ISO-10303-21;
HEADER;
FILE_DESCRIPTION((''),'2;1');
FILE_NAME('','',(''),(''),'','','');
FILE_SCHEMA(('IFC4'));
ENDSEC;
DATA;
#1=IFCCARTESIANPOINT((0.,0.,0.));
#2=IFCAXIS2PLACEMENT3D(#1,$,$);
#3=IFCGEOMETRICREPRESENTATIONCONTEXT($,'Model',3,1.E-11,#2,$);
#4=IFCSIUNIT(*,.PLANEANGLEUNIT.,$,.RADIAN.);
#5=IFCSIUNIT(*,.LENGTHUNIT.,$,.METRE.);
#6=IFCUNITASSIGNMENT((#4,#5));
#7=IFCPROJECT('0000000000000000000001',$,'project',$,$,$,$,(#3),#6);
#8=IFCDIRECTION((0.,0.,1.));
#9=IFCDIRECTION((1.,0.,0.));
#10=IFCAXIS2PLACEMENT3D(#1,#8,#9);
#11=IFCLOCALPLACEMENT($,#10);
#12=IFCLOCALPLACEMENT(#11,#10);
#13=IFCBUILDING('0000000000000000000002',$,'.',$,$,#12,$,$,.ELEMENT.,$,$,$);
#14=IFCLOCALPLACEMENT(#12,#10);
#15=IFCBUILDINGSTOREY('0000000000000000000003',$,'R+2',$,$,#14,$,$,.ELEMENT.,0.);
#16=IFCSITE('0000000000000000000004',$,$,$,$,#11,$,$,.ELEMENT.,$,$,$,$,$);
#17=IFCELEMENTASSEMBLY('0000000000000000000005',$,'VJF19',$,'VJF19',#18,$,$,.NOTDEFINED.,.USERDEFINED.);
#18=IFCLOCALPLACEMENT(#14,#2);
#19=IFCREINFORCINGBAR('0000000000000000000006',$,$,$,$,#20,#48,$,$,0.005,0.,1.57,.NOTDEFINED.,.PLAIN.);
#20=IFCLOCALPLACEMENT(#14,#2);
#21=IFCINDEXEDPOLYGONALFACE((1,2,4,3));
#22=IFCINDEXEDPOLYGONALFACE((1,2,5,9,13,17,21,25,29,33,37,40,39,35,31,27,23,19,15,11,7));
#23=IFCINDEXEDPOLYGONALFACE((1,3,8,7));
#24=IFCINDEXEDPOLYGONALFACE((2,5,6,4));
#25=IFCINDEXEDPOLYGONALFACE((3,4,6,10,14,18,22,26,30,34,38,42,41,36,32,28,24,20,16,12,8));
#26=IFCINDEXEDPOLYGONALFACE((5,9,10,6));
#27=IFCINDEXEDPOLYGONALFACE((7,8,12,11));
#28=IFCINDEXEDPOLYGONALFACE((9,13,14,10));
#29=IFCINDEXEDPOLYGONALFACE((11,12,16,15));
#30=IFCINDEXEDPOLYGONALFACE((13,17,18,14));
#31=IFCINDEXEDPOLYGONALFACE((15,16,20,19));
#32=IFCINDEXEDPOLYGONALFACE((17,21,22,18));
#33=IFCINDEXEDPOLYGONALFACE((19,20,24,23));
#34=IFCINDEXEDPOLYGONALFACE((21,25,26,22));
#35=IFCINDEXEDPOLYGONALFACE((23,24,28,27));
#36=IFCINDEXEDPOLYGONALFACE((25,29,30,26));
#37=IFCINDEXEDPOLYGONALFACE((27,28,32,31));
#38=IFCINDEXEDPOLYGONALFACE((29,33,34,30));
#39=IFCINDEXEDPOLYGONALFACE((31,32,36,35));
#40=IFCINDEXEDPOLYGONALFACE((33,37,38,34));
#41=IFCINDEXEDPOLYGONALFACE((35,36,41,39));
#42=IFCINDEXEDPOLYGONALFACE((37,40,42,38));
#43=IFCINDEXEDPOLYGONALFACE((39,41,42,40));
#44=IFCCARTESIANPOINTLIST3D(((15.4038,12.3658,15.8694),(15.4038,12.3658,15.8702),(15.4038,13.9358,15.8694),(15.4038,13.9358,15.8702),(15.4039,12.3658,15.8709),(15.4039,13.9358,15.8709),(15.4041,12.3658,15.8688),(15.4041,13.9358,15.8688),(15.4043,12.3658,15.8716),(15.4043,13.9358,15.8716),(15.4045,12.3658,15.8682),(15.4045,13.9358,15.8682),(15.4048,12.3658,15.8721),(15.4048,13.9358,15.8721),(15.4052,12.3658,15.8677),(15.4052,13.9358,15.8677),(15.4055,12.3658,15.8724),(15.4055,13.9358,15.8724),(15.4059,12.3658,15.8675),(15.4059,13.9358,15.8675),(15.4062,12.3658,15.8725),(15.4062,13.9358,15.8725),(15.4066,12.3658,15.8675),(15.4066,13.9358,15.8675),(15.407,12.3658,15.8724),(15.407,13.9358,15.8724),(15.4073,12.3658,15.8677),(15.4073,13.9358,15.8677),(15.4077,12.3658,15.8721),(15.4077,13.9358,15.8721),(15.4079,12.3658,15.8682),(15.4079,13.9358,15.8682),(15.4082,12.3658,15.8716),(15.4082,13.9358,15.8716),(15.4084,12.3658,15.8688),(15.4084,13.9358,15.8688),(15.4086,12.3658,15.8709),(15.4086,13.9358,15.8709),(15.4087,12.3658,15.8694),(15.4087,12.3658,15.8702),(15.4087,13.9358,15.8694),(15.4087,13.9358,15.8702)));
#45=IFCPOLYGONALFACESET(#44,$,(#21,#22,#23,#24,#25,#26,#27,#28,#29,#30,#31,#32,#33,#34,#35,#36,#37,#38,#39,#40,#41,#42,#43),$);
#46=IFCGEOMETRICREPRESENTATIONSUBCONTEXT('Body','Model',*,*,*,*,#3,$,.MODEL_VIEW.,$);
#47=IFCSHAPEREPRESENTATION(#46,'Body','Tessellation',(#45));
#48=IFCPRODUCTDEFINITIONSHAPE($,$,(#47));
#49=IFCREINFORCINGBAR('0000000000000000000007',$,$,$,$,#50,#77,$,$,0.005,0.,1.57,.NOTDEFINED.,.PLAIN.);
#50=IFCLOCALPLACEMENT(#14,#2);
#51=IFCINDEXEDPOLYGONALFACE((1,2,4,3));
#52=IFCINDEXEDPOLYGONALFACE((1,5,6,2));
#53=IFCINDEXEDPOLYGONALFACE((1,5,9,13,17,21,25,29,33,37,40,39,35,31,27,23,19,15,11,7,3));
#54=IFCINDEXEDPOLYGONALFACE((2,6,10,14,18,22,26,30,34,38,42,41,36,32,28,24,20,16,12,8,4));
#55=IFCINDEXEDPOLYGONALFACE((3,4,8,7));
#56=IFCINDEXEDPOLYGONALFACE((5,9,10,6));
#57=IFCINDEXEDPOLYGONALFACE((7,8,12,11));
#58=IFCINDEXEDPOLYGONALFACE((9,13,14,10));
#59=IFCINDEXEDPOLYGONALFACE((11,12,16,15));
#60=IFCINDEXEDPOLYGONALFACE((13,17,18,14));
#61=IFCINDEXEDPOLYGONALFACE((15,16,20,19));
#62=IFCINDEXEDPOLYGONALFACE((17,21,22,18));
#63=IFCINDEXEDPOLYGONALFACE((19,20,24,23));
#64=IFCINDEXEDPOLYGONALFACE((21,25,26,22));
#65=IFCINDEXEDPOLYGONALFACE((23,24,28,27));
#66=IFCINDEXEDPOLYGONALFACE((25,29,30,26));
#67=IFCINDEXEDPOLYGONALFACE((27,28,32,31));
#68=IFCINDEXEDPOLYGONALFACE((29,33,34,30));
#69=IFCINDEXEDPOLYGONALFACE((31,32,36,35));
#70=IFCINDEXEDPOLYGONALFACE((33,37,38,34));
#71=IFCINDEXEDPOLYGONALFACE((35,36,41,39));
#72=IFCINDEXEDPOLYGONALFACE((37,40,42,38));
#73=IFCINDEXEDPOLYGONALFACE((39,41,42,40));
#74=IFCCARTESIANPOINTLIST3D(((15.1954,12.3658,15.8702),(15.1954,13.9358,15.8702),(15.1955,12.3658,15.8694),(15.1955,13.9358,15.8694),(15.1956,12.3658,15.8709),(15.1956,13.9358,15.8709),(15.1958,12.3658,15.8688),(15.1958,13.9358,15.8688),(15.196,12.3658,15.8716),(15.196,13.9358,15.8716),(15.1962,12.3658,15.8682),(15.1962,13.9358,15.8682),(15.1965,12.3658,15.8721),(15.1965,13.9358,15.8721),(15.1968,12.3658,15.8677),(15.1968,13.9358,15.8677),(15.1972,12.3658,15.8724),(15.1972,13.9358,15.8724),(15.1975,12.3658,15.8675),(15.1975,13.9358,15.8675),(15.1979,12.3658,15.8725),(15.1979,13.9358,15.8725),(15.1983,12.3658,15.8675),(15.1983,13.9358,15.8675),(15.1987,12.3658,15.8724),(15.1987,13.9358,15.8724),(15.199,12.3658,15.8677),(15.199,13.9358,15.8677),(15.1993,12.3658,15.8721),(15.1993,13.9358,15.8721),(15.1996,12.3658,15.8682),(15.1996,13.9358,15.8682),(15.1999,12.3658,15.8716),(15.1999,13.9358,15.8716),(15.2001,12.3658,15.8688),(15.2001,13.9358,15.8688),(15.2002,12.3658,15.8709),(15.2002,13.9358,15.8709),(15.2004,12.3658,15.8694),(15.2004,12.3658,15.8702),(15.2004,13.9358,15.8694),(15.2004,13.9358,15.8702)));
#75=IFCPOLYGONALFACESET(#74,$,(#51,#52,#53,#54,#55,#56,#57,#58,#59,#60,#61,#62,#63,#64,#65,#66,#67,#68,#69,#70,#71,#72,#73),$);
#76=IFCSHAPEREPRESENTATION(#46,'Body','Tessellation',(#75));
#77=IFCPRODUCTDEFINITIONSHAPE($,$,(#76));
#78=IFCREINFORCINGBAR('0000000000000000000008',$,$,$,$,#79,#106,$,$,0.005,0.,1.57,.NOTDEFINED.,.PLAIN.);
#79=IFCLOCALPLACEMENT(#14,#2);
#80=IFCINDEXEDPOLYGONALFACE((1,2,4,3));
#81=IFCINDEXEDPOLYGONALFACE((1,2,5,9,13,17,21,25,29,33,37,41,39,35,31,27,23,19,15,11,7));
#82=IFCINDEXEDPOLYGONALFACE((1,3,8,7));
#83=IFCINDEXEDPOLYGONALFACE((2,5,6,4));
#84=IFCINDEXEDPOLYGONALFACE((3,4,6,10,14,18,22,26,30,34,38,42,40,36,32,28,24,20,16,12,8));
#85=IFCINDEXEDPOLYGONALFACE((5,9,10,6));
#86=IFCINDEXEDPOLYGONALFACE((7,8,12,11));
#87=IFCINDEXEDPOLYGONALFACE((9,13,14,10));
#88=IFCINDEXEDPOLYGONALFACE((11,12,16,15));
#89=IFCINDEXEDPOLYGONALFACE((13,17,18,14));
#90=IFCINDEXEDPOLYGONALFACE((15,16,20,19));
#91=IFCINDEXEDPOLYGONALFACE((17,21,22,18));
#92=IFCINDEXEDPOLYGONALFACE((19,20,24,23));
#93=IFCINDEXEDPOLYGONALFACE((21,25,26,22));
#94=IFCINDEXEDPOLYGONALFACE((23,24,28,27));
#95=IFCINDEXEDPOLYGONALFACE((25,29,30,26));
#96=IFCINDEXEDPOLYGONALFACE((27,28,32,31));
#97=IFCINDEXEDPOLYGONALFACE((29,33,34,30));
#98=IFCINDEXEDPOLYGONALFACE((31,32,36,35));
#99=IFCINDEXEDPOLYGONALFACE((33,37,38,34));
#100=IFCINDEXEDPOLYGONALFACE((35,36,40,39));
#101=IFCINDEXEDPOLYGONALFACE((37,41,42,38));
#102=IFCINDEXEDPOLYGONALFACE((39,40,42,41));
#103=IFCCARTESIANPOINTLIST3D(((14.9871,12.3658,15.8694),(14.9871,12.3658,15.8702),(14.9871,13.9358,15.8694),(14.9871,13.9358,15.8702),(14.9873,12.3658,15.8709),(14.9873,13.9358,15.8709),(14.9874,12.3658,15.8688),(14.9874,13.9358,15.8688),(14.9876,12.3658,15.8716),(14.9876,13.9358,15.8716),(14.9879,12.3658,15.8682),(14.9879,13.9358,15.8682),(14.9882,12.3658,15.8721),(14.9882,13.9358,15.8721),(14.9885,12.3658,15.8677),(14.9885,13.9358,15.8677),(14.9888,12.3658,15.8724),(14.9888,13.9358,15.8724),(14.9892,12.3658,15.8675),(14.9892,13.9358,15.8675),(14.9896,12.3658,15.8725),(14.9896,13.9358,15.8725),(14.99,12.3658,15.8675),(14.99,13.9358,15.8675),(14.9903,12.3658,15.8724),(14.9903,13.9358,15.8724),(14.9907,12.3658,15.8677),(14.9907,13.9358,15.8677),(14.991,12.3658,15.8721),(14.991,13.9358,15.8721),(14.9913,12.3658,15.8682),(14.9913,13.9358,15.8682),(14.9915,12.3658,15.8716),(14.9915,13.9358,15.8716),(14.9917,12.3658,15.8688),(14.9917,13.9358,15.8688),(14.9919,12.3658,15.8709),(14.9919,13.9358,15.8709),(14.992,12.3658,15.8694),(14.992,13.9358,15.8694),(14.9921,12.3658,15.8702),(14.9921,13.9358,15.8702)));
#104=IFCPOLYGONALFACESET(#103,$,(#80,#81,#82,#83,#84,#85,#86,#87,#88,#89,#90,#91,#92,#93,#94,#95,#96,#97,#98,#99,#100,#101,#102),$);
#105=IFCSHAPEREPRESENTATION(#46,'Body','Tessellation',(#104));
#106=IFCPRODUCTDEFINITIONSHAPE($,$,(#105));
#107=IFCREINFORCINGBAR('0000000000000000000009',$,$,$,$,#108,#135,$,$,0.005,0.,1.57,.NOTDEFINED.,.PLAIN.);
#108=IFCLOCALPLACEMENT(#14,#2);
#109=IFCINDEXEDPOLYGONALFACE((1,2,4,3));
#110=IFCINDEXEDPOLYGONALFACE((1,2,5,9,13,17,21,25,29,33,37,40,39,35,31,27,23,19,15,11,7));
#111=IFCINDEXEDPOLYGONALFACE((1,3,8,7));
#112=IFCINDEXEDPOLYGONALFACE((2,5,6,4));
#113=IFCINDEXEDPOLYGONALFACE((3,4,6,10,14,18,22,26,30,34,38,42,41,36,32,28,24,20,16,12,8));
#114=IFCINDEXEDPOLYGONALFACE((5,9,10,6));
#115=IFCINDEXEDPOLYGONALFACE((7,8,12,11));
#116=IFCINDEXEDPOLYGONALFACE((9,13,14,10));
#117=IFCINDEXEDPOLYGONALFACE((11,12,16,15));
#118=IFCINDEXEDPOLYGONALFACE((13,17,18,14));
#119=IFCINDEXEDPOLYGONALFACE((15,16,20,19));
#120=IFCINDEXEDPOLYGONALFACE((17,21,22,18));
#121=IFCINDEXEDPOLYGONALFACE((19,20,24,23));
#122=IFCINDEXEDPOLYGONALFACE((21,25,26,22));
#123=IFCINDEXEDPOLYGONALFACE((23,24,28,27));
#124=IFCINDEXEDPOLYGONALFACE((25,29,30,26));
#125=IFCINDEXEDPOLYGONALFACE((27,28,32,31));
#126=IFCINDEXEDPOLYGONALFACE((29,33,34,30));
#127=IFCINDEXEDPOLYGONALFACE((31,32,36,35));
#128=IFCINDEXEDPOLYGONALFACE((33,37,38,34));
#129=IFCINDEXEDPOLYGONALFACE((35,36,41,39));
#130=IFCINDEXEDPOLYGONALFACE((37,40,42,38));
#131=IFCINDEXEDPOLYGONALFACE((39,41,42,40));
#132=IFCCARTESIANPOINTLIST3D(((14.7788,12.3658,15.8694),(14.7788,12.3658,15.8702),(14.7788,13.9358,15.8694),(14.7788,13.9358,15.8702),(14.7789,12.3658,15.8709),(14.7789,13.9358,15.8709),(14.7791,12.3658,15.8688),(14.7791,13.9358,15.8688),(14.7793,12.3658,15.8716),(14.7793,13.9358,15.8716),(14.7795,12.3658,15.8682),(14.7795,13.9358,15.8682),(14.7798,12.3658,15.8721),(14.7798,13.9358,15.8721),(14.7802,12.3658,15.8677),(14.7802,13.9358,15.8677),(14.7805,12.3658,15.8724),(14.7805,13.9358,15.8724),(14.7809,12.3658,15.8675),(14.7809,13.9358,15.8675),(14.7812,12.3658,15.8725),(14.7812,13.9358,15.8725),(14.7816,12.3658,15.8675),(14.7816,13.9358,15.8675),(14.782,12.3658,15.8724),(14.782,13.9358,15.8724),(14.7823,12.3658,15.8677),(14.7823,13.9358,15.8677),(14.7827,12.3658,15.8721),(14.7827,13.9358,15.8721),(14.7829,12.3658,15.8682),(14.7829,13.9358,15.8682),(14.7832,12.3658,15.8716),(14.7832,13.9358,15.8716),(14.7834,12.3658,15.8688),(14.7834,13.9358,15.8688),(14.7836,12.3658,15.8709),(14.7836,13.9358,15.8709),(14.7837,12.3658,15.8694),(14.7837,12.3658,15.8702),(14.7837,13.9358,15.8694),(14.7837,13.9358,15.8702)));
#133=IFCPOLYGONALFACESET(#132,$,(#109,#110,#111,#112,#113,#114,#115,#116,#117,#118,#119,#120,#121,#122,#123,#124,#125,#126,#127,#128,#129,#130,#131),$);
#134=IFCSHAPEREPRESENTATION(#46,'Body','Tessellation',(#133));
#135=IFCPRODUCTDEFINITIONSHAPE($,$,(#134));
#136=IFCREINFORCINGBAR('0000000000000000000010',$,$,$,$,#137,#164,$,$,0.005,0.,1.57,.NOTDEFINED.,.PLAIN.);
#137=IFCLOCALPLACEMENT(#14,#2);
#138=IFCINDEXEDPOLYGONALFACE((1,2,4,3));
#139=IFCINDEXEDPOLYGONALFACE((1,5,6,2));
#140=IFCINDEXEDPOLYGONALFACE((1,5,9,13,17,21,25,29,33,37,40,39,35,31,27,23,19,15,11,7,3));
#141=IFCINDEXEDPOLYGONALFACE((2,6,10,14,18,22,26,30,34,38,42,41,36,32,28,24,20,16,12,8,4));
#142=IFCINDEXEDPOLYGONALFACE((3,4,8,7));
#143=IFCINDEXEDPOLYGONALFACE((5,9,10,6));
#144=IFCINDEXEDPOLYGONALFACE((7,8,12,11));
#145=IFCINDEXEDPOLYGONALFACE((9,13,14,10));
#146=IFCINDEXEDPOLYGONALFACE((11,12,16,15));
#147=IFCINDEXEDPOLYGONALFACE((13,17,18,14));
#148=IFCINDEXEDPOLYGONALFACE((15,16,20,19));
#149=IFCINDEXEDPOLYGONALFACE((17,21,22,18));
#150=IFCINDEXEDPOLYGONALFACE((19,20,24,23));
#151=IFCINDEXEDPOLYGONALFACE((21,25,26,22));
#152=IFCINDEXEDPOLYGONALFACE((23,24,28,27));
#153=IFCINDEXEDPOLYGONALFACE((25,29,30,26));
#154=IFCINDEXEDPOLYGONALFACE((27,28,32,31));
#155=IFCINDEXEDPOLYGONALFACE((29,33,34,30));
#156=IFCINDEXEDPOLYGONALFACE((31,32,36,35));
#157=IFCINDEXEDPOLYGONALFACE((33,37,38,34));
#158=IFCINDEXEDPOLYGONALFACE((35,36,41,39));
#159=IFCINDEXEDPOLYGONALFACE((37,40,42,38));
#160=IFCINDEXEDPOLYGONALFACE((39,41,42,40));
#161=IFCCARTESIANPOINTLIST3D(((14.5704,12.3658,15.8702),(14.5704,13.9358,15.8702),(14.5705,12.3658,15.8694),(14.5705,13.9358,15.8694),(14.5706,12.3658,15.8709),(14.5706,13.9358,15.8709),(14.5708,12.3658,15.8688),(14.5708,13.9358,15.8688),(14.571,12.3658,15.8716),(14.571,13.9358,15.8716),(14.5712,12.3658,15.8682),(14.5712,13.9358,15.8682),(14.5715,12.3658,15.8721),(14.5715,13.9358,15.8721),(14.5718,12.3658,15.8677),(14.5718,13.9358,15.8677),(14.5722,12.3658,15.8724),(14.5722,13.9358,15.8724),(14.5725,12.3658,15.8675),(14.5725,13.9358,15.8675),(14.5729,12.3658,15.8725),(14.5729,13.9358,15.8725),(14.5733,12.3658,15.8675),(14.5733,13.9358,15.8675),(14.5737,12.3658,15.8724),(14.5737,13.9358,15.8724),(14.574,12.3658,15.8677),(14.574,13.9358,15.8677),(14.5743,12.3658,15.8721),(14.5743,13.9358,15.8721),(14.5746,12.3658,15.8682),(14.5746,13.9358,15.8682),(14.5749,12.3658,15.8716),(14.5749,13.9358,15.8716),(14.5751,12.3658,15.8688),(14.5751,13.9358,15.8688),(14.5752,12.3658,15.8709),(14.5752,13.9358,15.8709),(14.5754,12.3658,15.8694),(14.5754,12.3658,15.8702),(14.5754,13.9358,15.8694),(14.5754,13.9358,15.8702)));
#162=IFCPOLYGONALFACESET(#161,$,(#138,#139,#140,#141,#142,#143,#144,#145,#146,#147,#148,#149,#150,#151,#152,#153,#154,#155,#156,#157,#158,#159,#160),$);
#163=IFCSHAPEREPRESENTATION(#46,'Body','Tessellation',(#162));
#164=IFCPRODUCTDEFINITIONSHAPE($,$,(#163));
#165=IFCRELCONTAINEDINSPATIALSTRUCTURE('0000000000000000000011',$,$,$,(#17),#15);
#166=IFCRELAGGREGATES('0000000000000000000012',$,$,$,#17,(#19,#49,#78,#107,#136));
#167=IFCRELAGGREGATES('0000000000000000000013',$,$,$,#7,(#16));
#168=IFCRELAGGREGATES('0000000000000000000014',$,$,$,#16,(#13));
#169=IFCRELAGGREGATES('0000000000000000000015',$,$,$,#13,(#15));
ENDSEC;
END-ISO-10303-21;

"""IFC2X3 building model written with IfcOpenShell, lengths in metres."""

from ifc_helpers import new_model, entity, si_unit, origin, origin_with_axes, place, context, subcontext, project, spatial, shape, element, aggregate, save


model = new_model("IFC2X3")

# Units and contexts
model_context = context("Model", 3, precision=1e-11, world=origin())
body_context = subcontext(model_context, "Body", "Model", "MODEL_VIEW")
ifc_project = project(units=[si_unit("PLANEANGLEUNIT", "RADIAN"), si_unit("LENGTHUNIT", "METRE")], contexts=[model_context])

# Site, building, storey
site_placement = place(None, origin_with_axes())
site = spatial("IfcSite", under=ifc_project, at=site_placement, CompositionType="ELEMENT")
building_placement = place(site_placement, origin_with_axes())
building = spatial("IfcBuilding", under=site, at=building_placement, Name=".", CompositionType="ELEMENT")
storey_placement = place(building_placement, origin_with_axes())
storey = spatial("IfcBuildingStorey", under=building, at=storey_placement, Name="R+2", CompositionType="ELEMENT", Elevation=0.0)

# Element assembly, reinforcing bars
assembly_1_placement = place(storey_placement, origin_with_axes())
assembly_1 = element("IfcElementAssembly", 1, at=assembly_1_placement, inside=storey, Name="VJF19", ObjectType="VJF19", AssemblyPlace="NOTDEFINED", PredefinedType="USERDEFINED")
reinforcing_bar_1_placement = place(assembly_1_placement, origin_with_axes())
reinforcing_bar_1 = element("IfcReinforcingBar", 2, at=reinforcing_bar_1_placement, BarLength=1.57, BarRole="NOTDEFINED", BarSurface="PLAIN", CrossSectionArea=0.0, NominalDiameter=0.005, shapes=[
    shape(body_context, "Body", "AdvancedSweptSolid", [entity("IfcSweptDiskSolid", entity("IfcPolyline", [entity("IfcCartesianPoint", [15.4062, 12.3658, 15.87]), entity("IfcCartesianPoint", [15.4062, 13.9358, 15.87])]), 0.0025, None, 0.0, 1.57)]),
    shape(body_context, "Body", "AdvancedSweptSolid", [entity("IfcSweptDiskSolid", entity("IfcPolyline", [entity("IfcCartesianPoint", [15.4062, 12.3658, 15.87]), entity("IfcCartesianPoint", [15.4062, 13.9358, 15.87])]), 0.0025, None, 0.0, 1.57)]),
])
reinforcing_bar_2_placement = place(assembly_1_placement, origin_with_axes())
reinforcing_bar_2 = element("IfcReinforcingBar", 3, at=reinforcing_bar_2_placement, BarLength=1.57, BarRole="NOTDEFINED", BarSurface="PLAIN", CrossSectionArea=0.0, NominalDiameter=0.005, shapes=[
    shape(body_context, "Body", "AdvancedSweptSolid", [entity("IfcSweptDiskSolid", entity("IfcPolyline", [entity("IfcCartesianPoint", [15.1979, 12.3658, 15.87]), entity("IfcCartesianPoint", [15.1979, 13.9358, 15.87])]), 0.0025, None, 0.0, 1.57)]),
    shape(body_context, "Body", "AdvancedSweptSolid", [entity("IfcSweptDiskSolid", entity("IfcPolyline", [entity("IfcCartesianPoint", [15.1979, 12.3658, 15.87]), entity("IfcCartesianPoint", [15.1979, 13.9358, 15.87])]), 0.0025, None, 0.0, 1.57)]),
])
reinforcing_bar_3_placement = place(assembly_1_placement, origin_with_axes())
reinforcing_bar_3 = element("IfcReinforcingBar", 4, at=reinforcing_bar_3_placement, BarLength=1.57, BarRole="NOTDEFINED", BarSurface="PLAIN", CrossSectionArea=0.0, NominalDiameter=0.005, shapes=[
    shape(body_context, "Body", "AdvancedSweptSolid", [entity("IfcSweptDiskSolid", entity("IfcPolyline", [entity("IfcCartesianPoint", [14.9896, 12.3658, 15.87]), entity("IfcCartesianPoint", [14.9896, 13.9358, 15.87])]), 0.0025, None, 0.0, 1.57)]),
    shape(body_context, "Body", "AdvancedSweptSolid", [entity("IfcSweptDiskSolid", entity("IfcPolyline", [entity("IfcCartesianPoint", [14.9896, 12.3658, 15.87]), entity("IfcCartesianPoint", [14.9896, 13.9358, 15.87])]), 0.0025, None, 0.0, 1.57)]),
])
reinforcing_bar_4_placement = place(assembly_1_placement, origin_with_axes())
reinforcing_bar_4 = element("IfcReinforcingBar", 5, at=reinforcing_bar_4_placement, BarLength=1.57, BarRole="NOTDEFINED", BarSurface="PLAIN", CrossSectionArea=0.0, NominalDiameter=0.005, shapes=[
    shape(body_context, "Body", "AdvancedSweptSolid", [entity("IfcSweptDiskSolid", entity("IfcPolyline", [entity("IfcCartesianPoint", [14.7812, 12.3658, 15.87]), entity("IfcCartesianPoint", [14.7812, 13.9358, 15.87])]), 0.0025, None, 0.0, 1.57)]),
    shape(body_context, "Body", "AdvancedSweptSolid", [entity("IfcSweptDiskSolid", entity("IfcPolyline", [entity("IfcCartesianPoint", [14.7812, 12.3658, 15.87]), entity("IfcCartesianPoint", [14.7812, 13.9358, 15.87])]), 0.0025, None, 0.0, 1.57)]),
])
reinforcing_bar_5_placement = place(assembly_1_placement, origin_with_axes())
reinforcing_bar_5 = element("IfcReinforcingBar", 6, at=reinforcing_bar_5_placement, BarLength=1.57, BarRole="NOTDEFINED", BarSurface="PLAIN", CrossSectionArea=0.0, NominalDiameter=0.005, shapes=[
    shape(body_context, "Body", "AdvancedSweptSolid", [entity("IfcSweptDiskSolid", entity("IfcPolyline", [entity("IfcCartesianPoint", [14.5729, 12.3658, 15.87]), entity("IfcCartesianPoint", [14.5729, 13.9358, 15.87])]), 0.0025, None, 0.0, 1.57)]),
    shape(body_context, "Body", "AdvancedSweptSolid", [entity("IfcSweptDiskSolid", entity("IfcPolyline", [entity("IfcCartesianPoint", [14.5729, 12.3658, 15.87]), entity("IfcCartesianPoint", [14.5729, 13.9358, 15.87])]), 0.0025, None, 0.0, 1.57)]),
])
aggregate(assembly_1, [reinforcing_bar_1, reinforcing_bar_2, reinforcing_bar_3, reinforcing_bar_4, reinforcing_bar_5])

save(model, "model.ifc")
